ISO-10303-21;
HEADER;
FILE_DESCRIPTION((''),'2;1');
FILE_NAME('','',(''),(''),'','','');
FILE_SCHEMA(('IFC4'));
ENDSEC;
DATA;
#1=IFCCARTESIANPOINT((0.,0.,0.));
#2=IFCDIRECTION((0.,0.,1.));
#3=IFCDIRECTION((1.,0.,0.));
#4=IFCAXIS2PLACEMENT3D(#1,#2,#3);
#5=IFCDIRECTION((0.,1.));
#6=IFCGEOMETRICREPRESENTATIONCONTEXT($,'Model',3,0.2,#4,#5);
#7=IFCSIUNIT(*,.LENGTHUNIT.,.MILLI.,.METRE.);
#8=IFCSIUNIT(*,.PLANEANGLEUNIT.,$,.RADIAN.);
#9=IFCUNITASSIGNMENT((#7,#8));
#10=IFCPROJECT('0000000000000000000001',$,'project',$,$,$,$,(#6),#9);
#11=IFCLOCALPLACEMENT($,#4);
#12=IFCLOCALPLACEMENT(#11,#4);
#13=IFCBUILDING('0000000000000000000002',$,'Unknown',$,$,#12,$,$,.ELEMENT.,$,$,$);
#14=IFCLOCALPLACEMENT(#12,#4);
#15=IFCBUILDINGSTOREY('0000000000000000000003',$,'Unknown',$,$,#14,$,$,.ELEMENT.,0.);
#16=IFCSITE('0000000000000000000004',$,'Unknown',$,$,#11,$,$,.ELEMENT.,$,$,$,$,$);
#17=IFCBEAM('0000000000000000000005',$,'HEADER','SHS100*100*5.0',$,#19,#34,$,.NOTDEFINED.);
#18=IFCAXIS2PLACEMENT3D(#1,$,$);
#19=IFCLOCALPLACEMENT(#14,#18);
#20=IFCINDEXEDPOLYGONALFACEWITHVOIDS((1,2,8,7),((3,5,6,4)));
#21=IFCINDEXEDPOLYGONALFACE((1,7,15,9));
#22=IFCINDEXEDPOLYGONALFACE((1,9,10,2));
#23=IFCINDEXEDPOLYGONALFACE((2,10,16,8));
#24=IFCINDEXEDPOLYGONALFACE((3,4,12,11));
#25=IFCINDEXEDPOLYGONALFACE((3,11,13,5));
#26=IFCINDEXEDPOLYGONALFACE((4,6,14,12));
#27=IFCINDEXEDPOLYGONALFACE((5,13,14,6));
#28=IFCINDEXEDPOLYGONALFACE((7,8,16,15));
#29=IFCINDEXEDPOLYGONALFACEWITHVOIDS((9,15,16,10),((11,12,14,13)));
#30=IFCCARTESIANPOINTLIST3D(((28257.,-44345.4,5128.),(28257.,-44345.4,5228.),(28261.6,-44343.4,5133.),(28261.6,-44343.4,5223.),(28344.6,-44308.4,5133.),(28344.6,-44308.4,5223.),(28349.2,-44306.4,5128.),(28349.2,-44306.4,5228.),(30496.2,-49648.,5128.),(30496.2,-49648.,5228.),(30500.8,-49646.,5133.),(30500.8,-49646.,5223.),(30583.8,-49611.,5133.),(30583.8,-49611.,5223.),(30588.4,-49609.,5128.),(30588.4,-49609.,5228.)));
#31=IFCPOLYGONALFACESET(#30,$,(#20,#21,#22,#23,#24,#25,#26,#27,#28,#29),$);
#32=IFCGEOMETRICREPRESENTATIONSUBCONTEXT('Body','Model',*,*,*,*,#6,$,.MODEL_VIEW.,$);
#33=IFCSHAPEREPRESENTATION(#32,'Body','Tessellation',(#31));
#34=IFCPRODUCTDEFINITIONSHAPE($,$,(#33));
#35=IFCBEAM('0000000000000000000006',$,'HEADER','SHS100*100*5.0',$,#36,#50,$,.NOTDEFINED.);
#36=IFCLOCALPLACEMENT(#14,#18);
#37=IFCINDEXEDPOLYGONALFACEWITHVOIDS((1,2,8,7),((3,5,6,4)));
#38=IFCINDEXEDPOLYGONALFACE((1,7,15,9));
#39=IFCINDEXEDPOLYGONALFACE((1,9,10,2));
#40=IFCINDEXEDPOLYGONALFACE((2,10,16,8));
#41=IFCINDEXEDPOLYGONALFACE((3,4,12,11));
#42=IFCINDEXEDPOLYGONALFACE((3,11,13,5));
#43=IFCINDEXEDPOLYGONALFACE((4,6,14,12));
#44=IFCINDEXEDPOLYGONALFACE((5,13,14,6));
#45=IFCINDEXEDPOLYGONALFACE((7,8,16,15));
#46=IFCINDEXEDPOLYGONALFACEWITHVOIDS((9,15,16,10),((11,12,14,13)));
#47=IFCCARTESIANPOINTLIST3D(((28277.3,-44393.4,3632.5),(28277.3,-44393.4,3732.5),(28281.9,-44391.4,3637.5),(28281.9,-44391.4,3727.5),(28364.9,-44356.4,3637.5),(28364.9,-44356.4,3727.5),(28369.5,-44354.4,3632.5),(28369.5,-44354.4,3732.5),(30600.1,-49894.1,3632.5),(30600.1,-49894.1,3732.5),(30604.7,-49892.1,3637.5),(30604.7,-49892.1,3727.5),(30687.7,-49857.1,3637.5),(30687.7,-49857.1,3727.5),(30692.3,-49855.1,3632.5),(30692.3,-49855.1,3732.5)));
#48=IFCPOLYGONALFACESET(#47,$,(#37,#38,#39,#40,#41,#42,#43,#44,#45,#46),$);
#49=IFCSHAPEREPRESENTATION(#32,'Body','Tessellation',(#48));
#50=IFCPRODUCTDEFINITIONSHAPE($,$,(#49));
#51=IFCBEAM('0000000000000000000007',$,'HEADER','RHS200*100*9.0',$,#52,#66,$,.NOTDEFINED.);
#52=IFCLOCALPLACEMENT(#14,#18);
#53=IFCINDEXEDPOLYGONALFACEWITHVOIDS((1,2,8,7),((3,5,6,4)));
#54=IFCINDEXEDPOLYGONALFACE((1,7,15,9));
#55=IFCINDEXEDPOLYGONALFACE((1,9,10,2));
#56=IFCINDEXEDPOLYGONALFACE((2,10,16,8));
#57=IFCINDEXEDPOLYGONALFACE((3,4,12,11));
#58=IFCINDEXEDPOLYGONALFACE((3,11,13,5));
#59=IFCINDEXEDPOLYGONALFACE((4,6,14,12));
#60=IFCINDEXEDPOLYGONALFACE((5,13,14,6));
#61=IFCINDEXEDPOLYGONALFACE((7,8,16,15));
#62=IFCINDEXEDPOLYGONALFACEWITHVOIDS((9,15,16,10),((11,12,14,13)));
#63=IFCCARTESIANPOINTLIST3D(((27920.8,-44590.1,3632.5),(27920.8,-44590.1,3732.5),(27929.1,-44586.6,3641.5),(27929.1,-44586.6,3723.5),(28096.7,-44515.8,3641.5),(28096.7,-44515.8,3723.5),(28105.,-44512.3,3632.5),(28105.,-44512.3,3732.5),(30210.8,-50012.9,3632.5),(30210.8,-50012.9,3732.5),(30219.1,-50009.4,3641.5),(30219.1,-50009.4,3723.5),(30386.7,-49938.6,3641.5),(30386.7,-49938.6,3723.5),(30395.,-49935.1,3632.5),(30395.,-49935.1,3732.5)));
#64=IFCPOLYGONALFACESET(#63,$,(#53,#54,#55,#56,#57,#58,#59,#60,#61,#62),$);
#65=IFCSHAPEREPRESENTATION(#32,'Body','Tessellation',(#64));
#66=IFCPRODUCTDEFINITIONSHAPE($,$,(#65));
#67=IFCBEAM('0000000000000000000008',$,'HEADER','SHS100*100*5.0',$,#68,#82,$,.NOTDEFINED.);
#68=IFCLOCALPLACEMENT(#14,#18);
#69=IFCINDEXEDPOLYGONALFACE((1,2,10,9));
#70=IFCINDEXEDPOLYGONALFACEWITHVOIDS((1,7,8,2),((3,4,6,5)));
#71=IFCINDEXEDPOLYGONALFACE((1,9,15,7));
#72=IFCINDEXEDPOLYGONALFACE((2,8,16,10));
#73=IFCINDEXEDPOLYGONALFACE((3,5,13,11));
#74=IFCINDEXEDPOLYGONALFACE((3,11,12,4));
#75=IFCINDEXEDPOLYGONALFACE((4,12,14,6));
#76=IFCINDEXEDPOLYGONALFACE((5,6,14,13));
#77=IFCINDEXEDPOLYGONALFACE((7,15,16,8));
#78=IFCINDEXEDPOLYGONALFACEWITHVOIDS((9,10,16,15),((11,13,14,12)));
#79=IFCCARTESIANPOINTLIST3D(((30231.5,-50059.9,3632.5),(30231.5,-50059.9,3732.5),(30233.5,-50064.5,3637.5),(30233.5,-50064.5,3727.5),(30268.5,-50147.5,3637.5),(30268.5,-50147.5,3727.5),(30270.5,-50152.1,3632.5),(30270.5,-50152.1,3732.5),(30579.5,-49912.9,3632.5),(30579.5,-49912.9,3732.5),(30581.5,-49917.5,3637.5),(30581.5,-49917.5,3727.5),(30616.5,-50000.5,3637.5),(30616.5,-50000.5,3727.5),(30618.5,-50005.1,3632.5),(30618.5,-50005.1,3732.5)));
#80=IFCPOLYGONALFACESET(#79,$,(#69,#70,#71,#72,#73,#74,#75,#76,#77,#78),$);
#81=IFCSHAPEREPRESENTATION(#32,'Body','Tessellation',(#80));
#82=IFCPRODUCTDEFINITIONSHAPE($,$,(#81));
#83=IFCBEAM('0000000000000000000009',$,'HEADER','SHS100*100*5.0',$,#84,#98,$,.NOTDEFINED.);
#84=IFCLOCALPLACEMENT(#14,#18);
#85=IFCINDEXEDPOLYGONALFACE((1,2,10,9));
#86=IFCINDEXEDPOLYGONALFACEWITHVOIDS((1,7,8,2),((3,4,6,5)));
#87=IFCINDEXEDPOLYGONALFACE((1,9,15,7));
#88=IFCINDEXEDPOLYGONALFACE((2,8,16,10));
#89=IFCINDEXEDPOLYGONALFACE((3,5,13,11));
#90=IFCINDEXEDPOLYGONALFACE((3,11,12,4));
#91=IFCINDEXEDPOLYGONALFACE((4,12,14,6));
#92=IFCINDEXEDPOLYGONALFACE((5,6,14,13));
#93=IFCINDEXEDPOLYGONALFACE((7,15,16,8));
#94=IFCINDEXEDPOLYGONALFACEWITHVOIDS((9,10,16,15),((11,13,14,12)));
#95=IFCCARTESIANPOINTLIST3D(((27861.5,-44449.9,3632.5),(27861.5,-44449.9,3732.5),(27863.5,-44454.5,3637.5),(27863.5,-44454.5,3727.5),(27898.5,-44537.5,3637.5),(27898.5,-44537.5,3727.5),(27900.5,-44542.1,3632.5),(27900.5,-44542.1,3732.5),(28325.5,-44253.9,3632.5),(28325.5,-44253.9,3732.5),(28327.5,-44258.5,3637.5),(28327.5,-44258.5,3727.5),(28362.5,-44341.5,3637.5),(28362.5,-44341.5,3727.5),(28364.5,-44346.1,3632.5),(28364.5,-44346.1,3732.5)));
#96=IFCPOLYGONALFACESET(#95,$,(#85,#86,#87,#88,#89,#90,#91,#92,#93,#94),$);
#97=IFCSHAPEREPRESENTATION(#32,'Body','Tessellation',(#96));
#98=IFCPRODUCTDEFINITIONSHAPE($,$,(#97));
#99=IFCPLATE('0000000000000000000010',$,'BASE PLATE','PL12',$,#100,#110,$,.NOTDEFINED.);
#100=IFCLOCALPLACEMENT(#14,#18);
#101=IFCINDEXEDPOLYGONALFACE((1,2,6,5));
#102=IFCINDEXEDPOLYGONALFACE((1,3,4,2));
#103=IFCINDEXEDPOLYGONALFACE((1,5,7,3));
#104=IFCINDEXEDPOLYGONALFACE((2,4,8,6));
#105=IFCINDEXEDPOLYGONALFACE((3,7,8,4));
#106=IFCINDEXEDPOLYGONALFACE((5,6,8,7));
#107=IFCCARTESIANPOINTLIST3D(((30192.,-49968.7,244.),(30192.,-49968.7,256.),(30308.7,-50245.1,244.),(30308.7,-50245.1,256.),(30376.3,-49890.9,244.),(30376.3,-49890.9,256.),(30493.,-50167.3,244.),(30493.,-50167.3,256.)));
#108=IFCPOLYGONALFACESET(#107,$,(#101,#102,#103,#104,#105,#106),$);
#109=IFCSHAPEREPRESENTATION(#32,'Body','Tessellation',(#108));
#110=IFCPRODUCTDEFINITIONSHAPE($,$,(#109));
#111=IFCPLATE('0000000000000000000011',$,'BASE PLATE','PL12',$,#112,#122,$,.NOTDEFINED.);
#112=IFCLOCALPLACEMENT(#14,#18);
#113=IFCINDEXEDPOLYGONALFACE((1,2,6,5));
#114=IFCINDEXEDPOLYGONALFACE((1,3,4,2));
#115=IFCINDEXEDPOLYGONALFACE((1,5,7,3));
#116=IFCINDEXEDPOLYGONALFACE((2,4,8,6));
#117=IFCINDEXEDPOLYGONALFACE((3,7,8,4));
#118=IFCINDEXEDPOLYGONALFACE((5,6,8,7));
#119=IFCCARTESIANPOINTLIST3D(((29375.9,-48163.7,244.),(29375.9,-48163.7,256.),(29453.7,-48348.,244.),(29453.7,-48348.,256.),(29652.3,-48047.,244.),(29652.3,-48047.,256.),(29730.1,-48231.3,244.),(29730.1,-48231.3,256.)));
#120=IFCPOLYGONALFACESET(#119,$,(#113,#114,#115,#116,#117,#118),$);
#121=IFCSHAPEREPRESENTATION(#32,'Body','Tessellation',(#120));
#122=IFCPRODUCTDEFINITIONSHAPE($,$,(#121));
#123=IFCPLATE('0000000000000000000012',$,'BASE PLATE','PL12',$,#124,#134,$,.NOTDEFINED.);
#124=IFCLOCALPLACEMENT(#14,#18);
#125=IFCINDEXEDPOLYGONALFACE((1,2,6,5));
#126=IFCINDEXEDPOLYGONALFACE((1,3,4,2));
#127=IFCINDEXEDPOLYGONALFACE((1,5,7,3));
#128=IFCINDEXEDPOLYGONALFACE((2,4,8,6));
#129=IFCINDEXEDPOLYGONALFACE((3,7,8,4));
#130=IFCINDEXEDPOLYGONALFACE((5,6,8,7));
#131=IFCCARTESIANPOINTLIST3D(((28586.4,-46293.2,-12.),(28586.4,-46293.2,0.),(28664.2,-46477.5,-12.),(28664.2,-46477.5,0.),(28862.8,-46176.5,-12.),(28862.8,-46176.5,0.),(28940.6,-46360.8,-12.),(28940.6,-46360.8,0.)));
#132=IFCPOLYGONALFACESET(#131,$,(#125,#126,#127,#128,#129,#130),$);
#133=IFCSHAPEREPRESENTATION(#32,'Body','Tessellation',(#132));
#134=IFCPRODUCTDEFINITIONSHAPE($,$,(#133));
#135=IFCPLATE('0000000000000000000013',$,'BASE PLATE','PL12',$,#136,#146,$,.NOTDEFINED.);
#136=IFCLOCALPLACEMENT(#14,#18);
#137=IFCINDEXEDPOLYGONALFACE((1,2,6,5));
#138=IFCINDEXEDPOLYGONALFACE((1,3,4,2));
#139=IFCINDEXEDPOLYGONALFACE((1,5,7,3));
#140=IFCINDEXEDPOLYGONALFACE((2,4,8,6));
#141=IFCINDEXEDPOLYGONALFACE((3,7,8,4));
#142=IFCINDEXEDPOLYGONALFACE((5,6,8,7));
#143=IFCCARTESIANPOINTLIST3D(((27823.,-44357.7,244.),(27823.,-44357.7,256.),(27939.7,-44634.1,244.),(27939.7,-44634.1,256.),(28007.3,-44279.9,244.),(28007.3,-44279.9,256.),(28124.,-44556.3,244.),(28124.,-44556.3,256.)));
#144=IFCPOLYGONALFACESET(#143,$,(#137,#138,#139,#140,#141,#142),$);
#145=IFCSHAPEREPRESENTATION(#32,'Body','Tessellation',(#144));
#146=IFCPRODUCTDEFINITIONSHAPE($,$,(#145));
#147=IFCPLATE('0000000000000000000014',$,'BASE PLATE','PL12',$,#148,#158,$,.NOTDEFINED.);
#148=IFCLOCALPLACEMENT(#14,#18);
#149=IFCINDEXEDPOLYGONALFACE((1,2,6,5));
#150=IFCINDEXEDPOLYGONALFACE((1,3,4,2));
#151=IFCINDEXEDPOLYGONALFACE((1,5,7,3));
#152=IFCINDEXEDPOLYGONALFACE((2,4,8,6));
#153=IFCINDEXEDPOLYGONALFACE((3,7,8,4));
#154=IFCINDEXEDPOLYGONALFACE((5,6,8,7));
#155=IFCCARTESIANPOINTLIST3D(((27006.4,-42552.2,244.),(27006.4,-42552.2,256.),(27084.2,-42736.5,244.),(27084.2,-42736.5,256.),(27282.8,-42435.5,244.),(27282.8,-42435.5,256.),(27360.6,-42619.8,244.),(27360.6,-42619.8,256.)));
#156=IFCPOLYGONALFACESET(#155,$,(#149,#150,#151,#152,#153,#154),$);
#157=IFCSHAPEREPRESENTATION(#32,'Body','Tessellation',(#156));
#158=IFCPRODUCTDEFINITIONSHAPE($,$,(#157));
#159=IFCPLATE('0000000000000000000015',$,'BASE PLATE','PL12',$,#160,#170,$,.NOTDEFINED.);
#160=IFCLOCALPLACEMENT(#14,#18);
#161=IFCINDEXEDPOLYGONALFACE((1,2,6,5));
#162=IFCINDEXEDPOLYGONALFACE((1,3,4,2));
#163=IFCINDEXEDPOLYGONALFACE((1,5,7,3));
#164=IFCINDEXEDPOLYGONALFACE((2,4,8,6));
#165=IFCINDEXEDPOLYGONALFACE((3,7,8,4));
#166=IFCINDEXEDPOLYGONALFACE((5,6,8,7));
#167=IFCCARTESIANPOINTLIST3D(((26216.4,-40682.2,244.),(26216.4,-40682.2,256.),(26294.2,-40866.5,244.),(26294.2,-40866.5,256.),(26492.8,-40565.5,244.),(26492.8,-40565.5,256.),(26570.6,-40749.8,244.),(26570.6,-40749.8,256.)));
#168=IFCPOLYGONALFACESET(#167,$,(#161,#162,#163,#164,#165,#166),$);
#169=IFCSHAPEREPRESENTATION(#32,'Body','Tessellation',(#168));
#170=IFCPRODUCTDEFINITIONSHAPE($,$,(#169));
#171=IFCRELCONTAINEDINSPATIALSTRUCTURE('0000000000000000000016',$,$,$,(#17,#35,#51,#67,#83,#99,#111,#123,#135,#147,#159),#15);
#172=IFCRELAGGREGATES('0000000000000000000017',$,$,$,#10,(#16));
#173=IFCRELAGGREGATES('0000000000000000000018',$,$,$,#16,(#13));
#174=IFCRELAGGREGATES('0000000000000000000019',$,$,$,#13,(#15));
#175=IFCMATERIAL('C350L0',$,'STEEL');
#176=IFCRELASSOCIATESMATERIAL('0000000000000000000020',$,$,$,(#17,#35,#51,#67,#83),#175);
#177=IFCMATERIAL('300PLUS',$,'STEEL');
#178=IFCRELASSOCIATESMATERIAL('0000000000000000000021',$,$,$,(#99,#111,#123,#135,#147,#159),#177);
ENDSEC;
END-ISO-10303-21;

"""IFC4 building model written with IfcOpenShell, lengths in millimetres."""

from ifc_helpers import new_model, si_unit, direction, frame, origin_with_axes, place, context, subcontext, project, spatial, line, indexed_curve, outline, extrude, material, element, save


model = new_model("IFC4")

# Units and contexts
model_context = context("Model", 3, precision=0.2, world=origin_with_axes(), true_north=direction((0.0, 1.0)))
body_context = subcontext(model_context, "Body", "Model", "MODEL_VIEW")
ifc_project = project(units=[si_unit("LENGTHUNIT", "METRE", prefix="MILLI"), si_unit("PLANEANGLEUNIT", "RADIAN")], contexts=[model_context])

# Site, building, storey
site_placement = place(None, origin_with_axes())
site = spatial("IfcSite", under=ifc_project, at=site_placement, Name="Unknown", CompositionType="ELEMENT")
building_placement = place(site_placement, origin_with_axes())
building = spatial("IfcBuilding", under=site, at=building_placement, Name="Unknown", CompositionType="ELEMENT")
storey_placement = place(building_placement, origin_with_axes())
storey = spatial("IfcBuildingStorey", under=building, at=storey_placement, Name="Unknown", CompositionType="ELEMENT", Elevation=0.0)

# Shared definitions
ifc_material_1 = material(Name="C350L0", Category="STEEL")

# Beams
beam_1_placement = place(storey_placement, frame((28303.1, -44325.9, 5178.0), z_axis=(0.0, 0.0, 1.0), x_axis=(0.38902, -0.921229, 0.0)))
element("IfcBeam", 1, at=beam_1_placement, inside=storey, material=ifc_material_1, Name="HEADER", Description="SHS100*100*5.0", PredefinedType="NOTDEFINED", context=body_context, shape_type="SolidModel", body=[
    extrude(outline(indexed_curve([(-50.0, -50.0), (50.0, -50.0), (50.0, 50.0), (-50.0, 50.0)], segments=[line(1, 2, 3, 4, 1)]), holes=[indexed_curve([(-45.0, -45.0), (-45.0, 45.0), (45.0, 45.0), (45.0, -45.0)], segments=[line(1, 2, 3, 4, 1)])]), frame((0.0, 0.0, 0.0), z_axis=(-1.0, 0.0, 0.0), x_axis=(0.0, 0.0, 1.0)), (0.0, 0.0, -1.0), 5756.0),
])
beam_2_placement = place(storey_placement, frame((28323.4, -44373.9, 3682.5), z_axis=(0.0, 0.0, 1.0), x_axis=(0.389012, -0.921233, 0.0)))
element("IfcBeam", 2, at=beam_2_placement, inside=storey, material=ifc_material_1, Name="HEADER", Description="SHS100*100*5.0", PredefinedType="NOTDEFINED", context=body_context, shape_type="SolidModel", body=[
    extrude(outline(indexed_curve([(-50.0, -50.0), (50.0, -50.0), (50.0, 50.0), (-50.0, 50.0)], segments=[line(1, 2, 3, 4, 1)]), holes=[indexed_curve([(-45.0, -45.0), (-45.0, 45.0), (45.0, 45.0), (45.0, -45.0)], segments=[line(1, 2, 3, 4, 1)])]), frame((0.0, 0.0, 0.0), z_axis=(-1.0, 0.0, 0.0), x_axis=(0.0, 0.0, 1.0)), (0.0, 0.0, -1.0), 5971.0),
])
beam_3_placement = place(storey_placement, frame((28012.9, -44551.2, 3682.5), z_axis=(0.0, 0.0, 1.0), x_axis=(0.389026, -0.921227, 0.0)))
element("IfcBeam", 3, at=beam_3_placement, inside=storey, material=ifc_material_1, Name="HEADER", Description="RHS200*100*9.0", PredefinedType="NOTDEFINED", context=body_context, shape_type="SolidModel", body=[
    extrude(outline(indexed_curve([(-50.0, -100.0), (50.0, -100.0), (50.0, 100.0), (-50.0, 100.0)], segments=[line(1, 2, 3, 4, 1)]), holes=[indexed_curve([(-41.0, -91.0), (-41.0, 91.0), (41.0, 91.0), (41.0, -91.0)], segments=[line(1, 2, 3, 4, 1)])]), frame((0.0, 0.0, 0.0), z_axis=(-1.0, 0.0, 0.0), x_axis=(0.0, 0.0, 1.0)), (0.0, 0.0, -1.0), 5886.5),
])
beam_4_placement = place(storey_placement, frame((30251.0, -50106.0, 3682.5), z_axis=(0.0, 0.0, 1.0), x_axis=(0.921186, 0.389122, 0.0)))
element("IfcBeam", 4, at=beam_4_placement, inside=storey, material=ifc_material_1, Name="HEADER", Description="SHS100*100*5.0", PredefinedType="NOTDEFINED", context=body_context, shape_type="SolidModel", body=[
    extrude(outline(indexed_curve([(-50.0, -50.0), (50.0, -50.0), (50.0, 50.0), (-50.0, 50.0)], segments=[line(1, 2, 3, 4, 1)]), holes=[indexed_curve([(-45.0, -45.0), (-45.0, 45.0), (45.0, 45.0), (45.0, -45.0)], segments=[line(1, 2, 3, 4, 1)])]), frame((0.0, 0.0, 0.0), z_axis=(-1.0, 0.0, 0.0), x_axis=(0.0, 0.0, 1.0)), (0.0, 0.0, -1.0), 377.8),
])
beam_5_placement = place(storey_placement, frame((27881.0, -44496.0, 3682.5), z_axis=(0.0, 0.0, 1.0), x_axis=(0.921186, 0.389122, 0.0)))
element("IfcBeam", 5, at=beam_5_placement, inside=storey, material=ifc_material_1, Name="HEADER", Description="SHS100*100*5.0", PredefinedType="NOTDEFINED", context=body_context, shape_type="SolidModel", body=[
    extrude(outline(indexed_curve([(-50.0, -50.0), (50.0, -50.0), (50.0, 50.0), (-50.0, 50.0)], segments=[line(1, 2, 3, 4, 1)]), holes=[indexed_curve([(-45.0, -45.0), (-45.0, 45.0), (45.0, 45.0), (45.0, -45.0)], segments=[line(1, 2, 3, 4, 1)])]), frame((0.0, 0.0, 0.0), z_axis=(-1.0, 0.0, 0.0), x_axis=(0.0, 0.0, 1.0)), (0.0, 0.0, -1.0), 503.7),
])

# Plates
ifc_material_2 = material(Name="300PLUS", Category="STEEL")
for number, where, z_axis, x_axis, name in (
    (6, (30493.0, -50167.3, 250.0), (0.0, 0.0, 1.0), (-0.388966, 0.921252, 0.0), "BASE PLATE"),
    (7, (29453.7, -48348.0, 250.0), (0.0, 0.0, 1.0), (0.921252, 0.388966, 0.0), "BASE PLATE"),
    (8, (28664.2, -46477.5, -6.0), (0.0, 0.0, 1.0), (0.921252, 0.388966, 0.0), "BASE PLATE"),
    (9, (28124.0, -44556.3, 250.0), (0.0, 0.0, 1.0), (-0.388966, 0.921252, 0.0), "BASE PLATE"),
    (10, (27084.2, -42736.5, 250.0), (0.0, 0.0, 1.0), (0.921252, 0.388966, 0.0), "BASE PLATE"),
    (11, (26294.2, -40866.5, 250.0), (0.0, 0.0, 1.0), (0.921252, 0.388966, 0.0), "BASE PLATE"),
):
    element("IfcPlate", number, at=place(storey_placement, frame(where, z_axis=z_axis, x_axis=x_axis)), inside=storey, material=ifc_material_2, Name=name, Description="PL12", PredefinedType="NOTDEFINED", context=body_context, shape_type="SolidModel", body=[
        extrude(outline(indexed_curve([(0.0, 0.0), (300.0, 0.0), (300.0, 200.0), (0.0, 200.0)], segments=[line(1, 2, 3, 4, 1)])), frame((0.0, 0.0, 6.0), z_axis=(0.0, 0.0, 1.0), x_axis=(1.0, 0.0, 0.0)), (0.0, 0.0, -1.0), 12.0),
    ])

save(model, "model.ifc")
